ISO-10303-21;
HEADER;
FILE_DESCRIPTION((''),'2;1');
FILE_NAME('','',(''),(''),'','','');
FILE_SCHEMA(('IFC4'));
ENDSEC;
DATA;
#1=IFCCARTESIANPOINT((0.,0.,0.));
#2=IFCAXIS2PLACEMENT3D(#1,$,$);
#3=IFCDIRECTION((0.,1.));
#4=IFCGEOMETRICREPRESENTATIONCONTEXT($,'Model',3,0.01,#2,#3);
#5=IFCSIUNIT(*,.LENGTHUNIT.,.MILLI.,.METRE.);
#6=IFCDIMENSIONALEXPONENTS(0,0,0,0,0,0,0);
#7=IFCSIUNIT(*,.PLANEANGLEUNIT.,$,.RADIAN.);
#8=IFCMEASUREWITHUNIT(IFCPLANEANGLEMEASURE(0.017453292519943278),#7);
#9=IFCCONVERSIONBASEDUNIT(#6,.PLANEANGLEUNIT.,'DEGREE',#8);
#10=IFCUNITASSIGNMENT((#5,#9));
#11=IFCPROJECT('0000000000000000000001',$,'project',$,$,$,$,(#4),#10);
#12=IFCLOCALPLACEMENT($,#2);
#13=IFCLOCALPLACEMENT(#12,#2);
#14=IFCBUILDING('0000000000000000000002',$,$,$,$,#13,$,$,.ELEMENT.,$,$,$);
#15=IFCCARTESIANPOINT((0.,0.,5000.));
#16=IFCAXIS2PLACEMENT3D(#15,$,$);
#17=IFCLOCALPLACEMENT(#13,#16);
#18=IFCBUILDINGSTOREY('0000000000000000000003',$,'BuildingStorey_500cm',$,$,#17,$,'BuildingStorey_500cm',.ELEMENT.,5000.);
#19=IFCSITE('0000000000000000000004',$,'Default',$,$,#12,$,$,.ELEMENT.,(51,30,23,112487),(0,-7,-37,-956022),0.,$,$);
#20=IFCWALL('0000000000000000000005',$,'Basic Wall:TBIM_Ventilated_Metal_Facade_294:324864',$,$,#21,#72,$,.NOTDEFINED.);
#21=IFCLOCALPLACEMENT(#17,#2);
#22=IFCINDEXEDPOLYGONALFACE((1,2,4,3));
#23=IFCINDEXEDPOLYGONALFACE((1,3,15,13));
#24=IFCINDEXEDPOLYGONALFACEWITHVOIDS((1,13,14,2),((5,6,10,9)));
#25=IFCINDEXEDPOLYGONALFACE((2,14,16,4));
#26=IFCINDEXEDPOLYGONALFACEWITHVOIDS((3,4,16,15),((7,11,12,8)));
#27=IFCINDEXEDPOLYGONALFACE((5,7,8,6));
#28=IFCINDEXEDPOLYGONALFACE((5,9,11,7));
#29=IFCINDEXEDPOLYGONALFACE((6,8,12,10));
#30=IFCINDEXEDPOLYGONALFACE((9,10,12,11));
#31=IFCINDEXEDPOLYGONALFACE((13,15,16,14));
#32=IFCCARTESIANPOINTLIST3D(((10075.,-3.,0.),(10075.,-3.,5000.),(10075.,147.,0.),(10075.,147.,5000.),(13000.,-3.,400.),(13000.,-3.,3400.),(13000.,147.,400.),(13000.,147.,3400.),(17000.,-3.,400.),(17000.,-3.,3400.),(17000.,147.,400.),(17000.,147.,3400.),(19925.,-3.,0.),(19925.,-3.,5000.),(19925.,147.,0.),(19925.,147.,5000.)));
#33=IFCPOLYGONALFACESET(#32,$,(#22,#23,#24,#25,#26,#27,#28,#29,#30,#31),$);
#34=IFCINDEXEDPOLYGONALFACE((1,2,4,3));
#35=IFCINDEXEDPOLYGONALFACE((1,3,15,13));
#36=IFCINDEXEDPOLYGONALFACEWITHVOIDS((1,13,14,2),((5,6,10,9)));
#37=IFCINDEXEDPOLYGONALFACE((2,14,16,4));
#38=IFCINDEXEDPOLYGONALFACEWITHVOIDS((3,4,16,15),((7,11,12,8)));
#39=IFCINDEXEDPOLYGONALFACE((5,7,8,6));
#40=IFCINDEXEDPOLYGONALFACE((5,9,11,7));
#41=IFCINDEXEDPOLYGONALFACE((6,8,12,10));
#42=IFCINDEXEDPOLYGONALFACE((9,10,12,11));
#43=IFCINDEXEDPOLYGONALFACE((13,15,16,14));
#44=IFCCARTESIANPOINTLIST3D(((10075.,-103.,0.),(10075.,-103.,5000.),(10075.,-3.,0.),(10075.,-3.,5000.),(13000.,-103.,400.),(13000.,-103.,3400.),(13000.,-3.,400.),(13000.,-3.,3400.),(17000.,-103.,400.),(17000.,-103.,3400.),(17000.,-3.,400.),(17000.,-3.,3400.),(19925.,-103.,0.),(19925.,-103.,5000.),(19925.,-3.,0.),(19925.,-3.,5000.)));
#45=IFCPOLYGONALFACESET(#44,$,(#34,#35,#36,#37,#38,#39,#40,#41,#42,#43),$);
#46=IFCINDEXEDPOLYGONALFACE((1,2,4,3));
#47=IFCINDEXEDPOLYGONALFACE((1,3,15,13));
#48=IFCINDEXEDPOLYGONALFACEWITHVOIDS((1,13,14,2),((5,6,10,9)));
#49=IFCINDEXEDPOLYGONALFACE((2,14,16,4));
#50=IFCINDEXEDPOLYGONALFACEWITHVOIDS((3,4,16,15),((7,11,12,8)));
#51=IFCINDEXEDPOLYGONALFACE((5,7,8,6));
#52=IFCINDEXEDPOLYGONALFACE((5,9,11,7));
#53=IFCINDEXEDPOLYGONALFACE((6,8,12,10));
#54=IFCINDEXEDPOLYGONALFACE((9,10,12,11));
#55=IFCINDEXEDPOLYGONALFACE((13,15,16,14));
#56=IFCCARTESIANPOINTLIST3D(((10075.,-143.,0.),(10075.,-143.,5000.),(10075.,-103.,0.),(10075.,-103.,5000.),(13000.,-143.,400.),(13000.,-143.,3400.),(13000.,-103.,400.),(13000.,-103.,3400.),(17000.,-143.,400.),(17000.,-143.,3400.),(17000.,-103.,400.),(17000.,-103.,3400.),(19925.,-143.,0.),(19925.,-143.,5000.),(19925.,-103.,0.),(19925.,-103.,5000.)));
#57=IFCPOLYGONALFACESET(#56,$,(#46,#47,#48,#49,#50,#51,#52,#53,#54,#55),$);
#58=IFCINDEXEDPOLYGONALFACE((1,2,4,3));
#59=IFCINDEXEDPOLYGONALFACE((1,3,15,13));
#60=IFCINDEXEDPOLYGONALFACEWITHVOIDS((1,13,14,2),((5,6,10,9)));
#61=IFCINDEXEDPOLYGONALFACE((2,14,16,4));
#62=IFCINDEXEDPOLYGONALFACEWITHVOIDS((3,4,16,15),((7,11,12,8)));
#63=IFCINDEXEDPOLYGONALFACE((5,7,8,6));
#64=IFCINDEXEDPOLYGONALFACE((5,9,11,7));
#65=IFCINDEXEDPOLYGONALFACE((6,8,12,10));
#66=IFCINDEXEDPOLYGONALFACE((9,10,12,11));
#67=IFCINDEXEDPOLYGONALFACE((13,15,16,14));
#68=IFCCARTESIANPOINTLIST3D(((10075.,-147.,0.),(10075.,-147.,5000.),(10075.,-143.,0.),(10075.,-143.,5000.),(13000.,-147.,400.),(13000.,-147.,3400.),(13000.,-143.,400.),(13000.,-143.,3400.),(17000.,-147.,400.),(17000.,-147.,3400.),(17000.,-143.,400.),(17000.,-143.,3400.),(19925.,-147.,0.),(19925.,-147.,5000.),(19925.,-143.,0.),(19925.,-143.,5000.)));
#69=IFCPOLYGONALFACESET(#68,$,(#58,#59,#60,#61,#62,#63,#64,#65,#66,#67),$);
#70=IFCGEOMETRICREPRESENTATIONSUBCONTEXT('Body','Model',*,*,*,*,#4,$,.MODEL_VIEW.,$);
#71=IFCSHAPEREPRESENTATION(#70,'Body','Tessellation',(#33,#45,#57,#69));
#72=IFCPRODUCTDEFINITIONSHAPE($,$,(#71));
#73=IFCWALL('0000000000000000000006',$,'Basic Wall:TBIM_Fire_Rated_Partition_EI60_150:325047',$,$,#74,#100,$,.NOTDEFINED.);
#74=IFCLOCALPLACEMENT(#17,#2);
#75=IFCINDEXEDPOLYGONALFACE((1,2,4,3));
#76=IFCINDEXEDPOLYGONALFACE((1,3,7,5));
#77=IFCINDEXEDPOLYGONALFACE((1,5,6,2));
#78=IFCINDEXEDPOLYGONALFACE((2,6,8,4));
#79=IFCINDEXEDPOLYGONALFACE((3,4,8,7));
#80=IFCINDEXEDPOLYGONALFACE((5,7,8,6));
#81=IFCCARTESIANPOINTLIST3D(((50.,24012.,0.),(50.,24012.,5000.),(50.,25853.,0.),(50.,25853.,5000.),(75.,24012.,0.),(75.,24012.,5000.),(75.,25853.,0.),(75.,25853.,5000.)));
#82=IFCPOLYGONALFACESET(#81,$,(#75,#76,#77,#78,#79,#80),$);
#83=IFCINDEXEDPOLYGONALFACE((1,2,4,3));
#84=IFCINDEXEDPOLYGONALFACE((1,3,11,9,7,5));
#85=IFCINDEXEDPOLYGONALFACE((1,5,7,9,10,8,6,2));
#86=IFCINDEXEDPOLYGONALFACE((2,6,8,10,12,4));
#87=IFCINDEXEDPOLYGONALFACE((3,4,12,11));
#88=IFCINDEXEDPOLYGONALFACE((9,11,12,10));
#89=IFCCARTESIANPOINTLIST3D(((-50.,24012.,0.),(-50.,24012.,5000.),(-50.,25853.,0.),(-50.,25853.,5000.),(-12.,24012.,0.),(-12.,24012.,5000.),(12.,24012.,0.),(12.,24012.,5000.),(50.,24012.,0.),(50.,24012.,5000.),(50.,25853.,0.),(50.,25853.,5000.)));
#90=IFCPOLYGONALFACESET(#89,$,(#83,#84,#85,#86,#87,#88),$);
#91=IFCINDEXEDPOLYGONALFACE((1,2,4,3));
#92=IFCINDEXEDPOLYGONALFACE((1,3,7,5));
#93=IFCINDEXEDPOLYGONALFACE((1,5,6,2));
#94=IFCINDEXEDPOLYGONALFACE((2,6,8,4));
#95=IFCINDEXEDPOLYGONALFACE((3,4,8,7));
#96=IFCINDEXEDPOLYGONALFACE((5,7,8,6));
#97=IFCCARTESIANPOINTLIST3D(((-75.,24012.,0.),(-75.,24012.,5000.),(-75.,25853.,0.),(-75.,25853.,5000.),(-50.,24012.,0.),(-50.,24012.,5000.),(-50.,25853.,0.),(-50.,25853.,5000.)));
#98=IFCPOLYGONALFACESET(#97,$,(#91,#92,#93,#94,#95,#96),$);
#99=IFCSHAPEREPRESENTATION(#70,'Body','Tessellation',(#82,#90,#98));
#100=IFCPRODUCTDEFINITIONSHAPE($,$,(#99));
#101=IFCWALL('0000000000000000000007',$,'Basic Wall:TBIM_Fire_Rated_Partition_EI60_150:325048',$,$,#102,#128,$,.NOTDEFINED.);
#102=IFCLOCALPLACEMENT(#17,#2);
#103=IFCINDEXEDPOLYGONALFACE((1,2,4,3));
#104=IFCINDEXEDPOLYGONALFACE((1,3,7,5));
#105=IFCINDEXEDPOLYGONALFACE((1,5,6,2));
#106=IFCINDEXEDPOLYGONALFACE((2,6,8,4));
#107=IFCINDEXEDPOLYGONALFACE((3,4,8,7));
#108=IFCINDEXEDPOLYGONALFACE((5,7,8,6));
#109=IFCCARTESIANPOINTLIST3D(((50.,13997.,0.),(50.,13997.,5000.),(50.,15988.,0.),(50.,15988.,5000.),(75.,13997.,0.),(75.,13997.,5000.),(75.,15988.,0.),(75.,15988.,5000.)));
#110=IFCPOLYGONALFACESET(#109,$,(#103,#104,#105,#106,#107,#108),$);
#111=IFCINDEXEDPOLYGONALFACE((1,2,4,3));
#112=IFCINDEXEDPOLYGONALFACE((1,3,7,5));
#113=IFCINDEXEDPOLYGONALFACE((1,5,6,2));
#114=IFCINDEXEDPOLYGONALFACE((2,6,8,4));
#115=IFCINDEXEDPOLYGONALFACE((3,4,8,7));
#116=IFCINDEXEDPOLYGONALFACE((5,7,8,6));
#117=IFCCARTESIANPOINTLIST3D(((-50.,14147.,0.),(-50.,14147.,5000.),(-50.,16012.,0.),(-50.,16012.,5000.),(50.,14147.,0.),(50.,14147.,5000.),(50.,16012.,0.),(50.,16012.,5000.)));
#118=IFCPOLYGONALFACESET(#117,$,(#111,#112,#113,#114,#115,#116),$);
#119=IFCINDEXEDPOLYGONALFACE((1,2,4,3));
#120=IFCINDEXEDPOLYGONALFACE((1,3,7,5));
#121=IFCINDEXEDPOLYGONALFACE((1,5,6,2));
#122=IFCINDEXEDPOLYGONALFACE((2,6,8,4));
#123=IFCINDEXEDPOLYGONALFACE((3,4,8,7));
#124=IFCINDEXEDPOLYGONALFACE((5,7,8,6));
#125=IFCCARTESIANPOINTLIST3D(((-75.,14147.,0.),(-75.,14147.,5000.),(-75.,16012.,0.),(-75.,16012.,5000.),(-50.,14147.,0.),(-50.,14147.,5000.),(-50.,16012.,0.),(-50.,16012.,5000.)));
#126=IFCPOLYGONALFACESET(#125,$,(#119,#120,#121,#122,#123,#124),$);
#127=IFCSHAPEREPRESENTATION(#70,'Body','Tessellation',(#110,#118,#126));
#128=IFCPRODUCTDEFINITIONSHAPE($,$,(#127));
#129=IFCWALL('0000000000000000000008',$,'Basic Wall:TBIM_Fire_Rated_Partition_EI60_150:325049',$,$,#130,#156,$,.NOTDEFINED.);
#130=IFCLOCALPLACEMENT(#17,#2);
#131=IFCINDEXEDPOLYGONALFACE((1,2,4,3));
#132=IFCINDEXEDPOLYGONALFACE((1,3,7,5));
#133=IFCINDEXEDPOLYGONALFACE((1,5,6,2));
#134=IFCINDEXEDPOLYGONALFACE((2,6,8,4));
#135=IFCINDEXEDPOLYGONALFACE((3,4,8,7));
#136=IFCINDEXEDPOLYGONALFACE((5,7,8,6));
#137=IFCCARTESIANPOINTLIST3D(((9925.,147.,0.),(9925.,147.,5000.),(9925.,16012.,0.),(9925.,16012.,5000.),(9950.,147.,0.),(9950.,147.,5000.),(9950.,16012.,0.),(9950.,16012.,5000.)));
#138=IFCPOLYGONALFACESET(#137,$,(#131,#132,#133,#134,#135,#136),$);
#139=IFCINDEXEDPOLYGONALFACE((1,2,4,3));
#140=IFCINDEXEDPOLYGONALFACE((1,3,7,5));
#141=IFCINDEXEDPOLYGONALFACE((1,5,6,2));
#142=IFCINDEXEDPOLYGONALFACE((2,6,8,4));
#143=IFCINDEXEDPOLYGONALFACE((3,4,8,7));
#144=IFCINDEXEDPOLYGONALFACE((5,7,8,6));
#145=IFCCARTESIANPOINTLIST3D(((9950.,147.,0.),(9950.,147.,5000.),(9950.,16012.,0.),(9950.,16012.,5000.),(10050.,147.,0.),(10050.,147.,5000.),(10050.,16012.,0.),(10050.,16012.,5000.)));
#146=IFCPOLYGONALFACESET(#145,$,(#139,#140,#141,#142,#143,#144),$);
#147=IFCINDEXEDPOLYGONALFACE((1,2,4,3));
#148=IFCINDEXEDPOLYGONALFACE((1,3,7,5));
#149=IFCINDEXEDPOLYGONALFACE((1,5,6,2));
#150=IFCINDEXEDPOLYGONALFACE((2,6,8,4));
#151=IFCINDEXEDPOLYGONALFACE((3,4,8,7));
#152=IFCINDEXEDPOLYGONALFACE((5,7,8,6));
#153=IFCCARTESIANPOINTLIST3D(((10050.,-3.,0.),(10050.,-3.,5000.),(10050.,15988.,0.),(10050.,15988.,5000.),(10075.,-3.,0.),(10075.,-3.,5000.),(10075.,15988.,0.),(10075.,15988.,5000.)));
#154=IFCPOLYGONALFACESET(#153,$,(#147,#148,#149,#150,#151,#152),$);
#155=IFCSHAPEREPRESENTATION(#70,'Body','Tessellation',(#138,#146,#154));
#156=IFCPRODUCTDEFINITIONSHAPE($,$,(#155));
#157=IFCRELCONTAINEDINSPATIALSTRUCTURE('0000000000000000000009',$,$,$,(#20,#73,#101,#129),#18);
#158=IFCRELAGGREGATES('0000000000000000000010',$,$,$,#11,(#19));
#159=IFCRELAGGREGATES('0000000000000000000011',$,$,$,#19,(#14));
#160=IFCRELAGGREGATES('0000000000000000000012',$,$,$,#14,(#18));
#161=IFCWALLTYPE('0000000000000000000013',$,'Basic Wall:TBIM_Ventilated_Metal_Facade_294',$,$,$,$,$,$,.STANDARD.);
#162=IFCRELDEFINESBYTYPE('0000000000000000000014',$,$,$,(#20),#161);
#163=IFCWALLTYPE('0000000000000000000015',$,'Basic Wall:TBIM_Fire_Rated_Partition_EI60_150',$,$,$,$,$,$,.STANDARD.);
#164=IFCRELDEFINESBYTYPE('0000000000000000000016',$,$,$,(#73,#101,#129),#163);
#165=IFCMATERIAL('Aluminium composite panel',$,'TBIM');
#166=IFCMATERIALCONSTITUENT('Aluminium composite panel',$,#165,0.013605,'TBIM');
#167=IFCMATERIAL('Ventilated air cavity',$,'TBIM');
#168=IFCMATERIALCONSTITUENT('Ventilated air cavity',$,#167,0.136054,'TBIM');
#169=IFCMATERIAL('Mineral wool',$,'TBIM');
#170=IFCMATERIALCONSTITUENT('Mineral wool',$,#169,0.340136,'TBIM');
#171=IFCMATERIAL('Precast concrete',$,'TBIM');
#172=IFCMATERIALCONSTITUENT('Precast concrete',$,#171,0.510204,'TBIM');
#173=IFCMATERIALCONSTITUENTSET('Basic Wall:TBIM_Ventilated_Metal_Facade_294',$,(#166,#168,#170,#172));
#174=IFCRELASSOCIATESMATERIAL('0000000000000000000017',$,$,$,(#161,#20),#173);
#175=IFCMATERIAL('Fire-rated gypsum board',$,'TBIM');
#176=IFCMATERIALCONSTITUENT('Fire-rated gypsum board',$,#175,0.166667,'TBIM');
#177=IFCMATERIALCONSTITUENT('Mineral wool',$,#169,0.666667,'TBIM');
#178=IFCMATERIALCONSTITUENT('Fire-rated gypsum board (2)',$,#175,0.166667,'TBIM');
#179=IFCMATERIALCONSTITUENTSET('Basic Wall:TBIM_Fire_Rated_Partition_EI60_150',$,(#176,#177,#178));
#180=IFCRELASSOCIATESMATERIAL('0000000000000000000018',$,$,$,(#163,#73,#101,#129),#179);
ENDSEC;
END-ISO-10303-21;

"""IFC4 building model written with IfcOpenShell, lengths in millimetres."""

from ifc_helpers import new_model, entity, si_unit, converted_unit, direction, frame, origin, place, context, subcontext, project, spatial, indexed_curve, outline, extrude, material, constituent, constituent_set, type_object, element, save


model = new_model("IFC4")

# Units and contexts
model_context = context("Model", 3, precision=0.01, world=origin(), true_north=direction((0.0, 1.0)))
body_context = subcontext(model_context, "Body", "Model", "MODEL_VIEW")
ifc_project = project(units=[si_unit("LENGTHUNIT", "METRE", prefix="MILLI"), converted_unit("PLANEANGLEUNIT", "DEGREE", entity("IfcPlaneAngleMeasure", 0.017453292519943278), si_unit("PLANEANGLEUNIT", "RADIAN"), dimensions=[0, 0, 0, 0, 0, 0, 0])], contexts=[model_context])

# Site, building, storey
site_placement = place(None, origin())
site = spatial("IfcSite", under=ifc_project, at=site_placement, Name="Default", CompositionType="ELEMENT", RefLatitude=(51, 30, 23, 112487), RefLongitude=(0, -7, -37, -956022), RefElevation=0.0)
building_placement = place(site_placement, origin())
building = spatial("IfcBuilding", under=site, at=building_placement, CompositionType="ELEMENT")
storey_placement = place(building_placement, frame((0.0, 0.0, 5000.0)))
storey = spatial("IfcBuildingStorey", under=building, at=storey_placement, Name="BuildingStorey_500cm", LongName="BuildingStorey_500cm", CompositionType="ELEMENT", Elevation=5000.0)

# Shared definitions
ifc_material_1 = material(Name="Aluminium composite panel", Category="TBIM")
ifc_constituent_1 = constituent(ifc_material_1, Name="Aluminium composite panel", Category="TBIM", fraction=0.013605)
ifc_material_2 = material(Name="Ventilated air cavity", Category="TBIM")
ifc_constituent_2 = constituent(ifc_material_2, Name="Ventilated air cavity", Category="TBIM", fraction=0.136054)
ifc_material_3 = material(Name="Mineral wool", Category="TBIM")
ifc_constituent_3 = constituent(ifc_material_3, Name="Mineral wool", Category="TBIM", fraction=0.340136)
ifc_material_4 = material(Name="Precast concrete", Category="TBIM")
ifc_constituent_4 = constituent(ifc_material_4, Name="Precast concrete", Category="TBIM", fraction=0.510204)
ifc_constituent_set_1 = constituent_set(constituents=[ifc_constituent_1, ifc_constituent_2, ifc_constituent_3, ifc_constituent_4], Name="Basic Wall:TBIM_Ventilated_Metal_Facade_294")
wall_type_1 = type_object("IfcWallType", Name="Basic Wall:TBIM_Ventilated_Metal_Facade_294", PredefinedType="STANDARD", material=ifc_constituent_set_1)

# Wall, opening
wall_1_placement = place(storey_placement, frame((10075.0, 0.0, 0.0)))
wall_1 = element("IfcWall", 1, at=wall_1_placement, inside=storey, type_object=wall_type_1, material=ifc_constituent_set_1, Name="Basic Wall:TBIM_Ventilated_Metal_Facade_294:324864", PredefinedType="NOTDEFINED", context=body_context, shape_type="SweptSolid", body=[
    extrude(outline(indexed_curve([(-2500.0, -4925.0), (2500.0, -4925.0), (2500.0, 4925.0), (-2500.0, 4925.0), (-2500.0, -4925.0)], self_intersect=False), holes=[indexed_curve([(-2100.0, -2000.0), (-2100.0, 2000.0), (900.0, 2000.0), (900.0, -2000.0), (-2100.0, -2000.0)], self_intersect=False)]), frame((4925.0, -3.0, 2500.0), z_axis=(0.0, 1.0, 0.0), x_axis=(0.0, 0.0, 1.0)), (0.0, 0.0, 1.0), 150.0),
    extrude(outline(indexed_curve([(-2500.0, -4925.0), (2500.0, -4925.0), (2500.0, 4925.0), (-2500.0, 4925.0), (-2500.0, -4925.0)], self_intersect=False), holes=[indexed_curve([(-2100.0, -2000.0), (-2100.0, 2000.0), (900.0, 2000.0), (900.0, -2000.0), (-2100.0, -2000.0)], self_intersect=False)]), frame((4925.0, -103.0, 2500.0), z_axis=(0.0, 1.0, 0.0), x_axis=(0.0, 0.0, 1.0)), (0.0, 0.0, 1.0), 100.0),
    extrude(outline(indexed_curve([(-2500.0, -4925.0), (2500.0, -4925.0), (2500.0, 4925.0), (-2500.0, 4925.0), (-2500.0, -4925.0)], self_intersect=False), holes=[indexed_curve([(-2100.0, -2000.0), (-2100.0, 2000.0), (900.0, 2000.0), (900.0, -2000.0), (-2100.0, -2000.0)], self_intersect=False)]), frame((4925.0, -143.0, 2500.0), z_axis=(0.0, 1.0, 0.0), x_axis=(0.0, 0.0, 1.0)), (0.0, 0.0, 1.0), 40.0),
    extrude(outline(indexed_curve([(-2500.0, -4925.0), (2500.0, -4925.0), (2500.0, 4925.0), (-2500.0, 4925.0), (-2500.0, -4925.0)], self_intersect=False), holes=[indexed_curve([(900.0, -2000.0), (-2100.0, -2000.0), (-2100.0, 2000.0), (900.0, 2000.0), (900.0, -2000.0)], self_intersect=False)]), frame((4925.0, -147.0, 2500.0), z_axis=(0.0, 1.0, 0.0), x_axis=(0.0, 0.0, 1.0)), (0.0, 0.0, 1.0), 4.0),
])
opening_1_placement = place(wall_1_placement, frame((2925.0, -147.0, 400.0)))
element("IfcOpeningElement", 2, at=opening_1_placement, cuts=wall_1, PredefinedType="OPENING", context=body_context, shape_type="SweptSolid", body=[
    extrude(outline(indexed_curve([(3000.0, 0.0), (3000.0, 4000.0), (0.0, 4000.0), (0.0, 0.0), (3000.0, 0.0)], self_intersect=False)), frame((0.0, 0.0, 0.0), z_axis=(0.0, 1.0, 0.0), x_axis=(0.0, 0.0, 1.0)), (0.0, 0.0, 1.0), 294.0),
])

# Walls
ifc_material_5 = material(Name="Fire-rated gypsum board", Category="TBIM")
ifc_constituent_5 = constituent(ifc_material_5, Name="Fire-rated gypsum board", Category="TBIM", fraction=0.166667)
ifc_constituent_6 = constituent(ifc_material_3, Name="Mineral wool", Category="TBIM", fraction=0.666667)
ifc_constituent_7 = constituent(ifc_material_5, Name="Fire-rated gypsum board (2)", Category="TBIM", fraction=0.166667)
ifc_constituent_set_2 = constituent_set(constituents=[ifc_constituent_5, ifc_constituent_6, ifc_constituent_7], Name="Basic Wall:TBIM_Fire_Rated_Partition_EI60_150")
wall_type_2 = type_object("IfcWallType", Name="Basic Wall:TBIM_Fire_Rated_Partition_EI60_150", PredefinedType="STANDARD", material=ifc_constituent_set_2)
wall_2_placement = place(storey_placement, frame((0.0, 25853.0, 0.0), z_axis=(0.0, 0.0, 1.0), x_axis=(0.0, -1.0, 0.0)))
element("IfcWall", 3, at=wall_2_placement, inside=storey, type_object=wall_type_2, material=ifc_constituent_set_2, Name="Basic Wall:TBIM_Fire_Rated_Partition_EI60_150:325047", PredefinedType="NOTDEFINED", context=body_context, shape_type="SweptSolid", body=[
    extrude(outline(indexed_curve([(-12.5, -920.5), (12.5, -920.5), (12.5, 920.5), (-12.5, 920.5), (-12.5, -920.5)], self_intersect=False)), frame((920.5, 62.5, 0.0), z_axis=(0.0, 0.0, 1.0), x_axis=(0.0, -1.0, 0.0)), (0.0, 0.0, 1.0), 5000.0),
    extrude(outline(indexed_curve([(12.0, -613.7), (50.0, -613.7), (50.0, 1227.3), (-50.0, 1227.3), (-50.0, -613.7), (-12.0, -613.7), (12.0, -613.7)], self_intersect=False)), frame((1227.3, 0.0, 0.0), z_axis=(0.0, 0.0, 1.0), x_axis=(0.0, 1.0, 0.0)), (0.0, 0.0, 1.0), 5000.0),
    extrude(outline(indexed_curve([(-12.5, -920.5), (12.5, -920.5), (12.5, 920.5), (-12.5, 920.5), (-12.5, -920.5)], self_intersect=False)), frame((920.5, -62.5, 0.0), z_axis=(0.0, 0.0, 1.0), x_axis=(0.0, 1.0, 0.0)), (0.0, 0.0, 1.0), 5000.0),
])
wall_3_placement = place(storey_placement, frame((0.0, 15988.0, 0.0), z_axis=(0.0, 0.0, 1.0), x_axis=(0.0, -1.0, 0.0)))
element("IfcWall", 4, at=wall_3_placement, inside=storey, type_object=wall_type_2, material=ifc_constituent_set_2, Name="Basic Wall:TBIM_Fire_Rated_Partition_EI60_150:325048", PredefinedType="NOTDEFINED", context=body_context, shape_type="SweptSolid", body=[
    extrude(outline(indexed_curve([(-12.5, -995.5), (12.5, -995.5), (12.5, 995.5), (-12.5, 995.5), (-12.5, -995.5)], self_intersect=False)), frame((995.5, 62.5, 0.0), z_axis=(0.0, 0.0, 1.0), x_axis=(0.0, -1.0, 0.0)), (0.0, 0.0, 1.0), 5000.0),
    extrude(outline(indexed_curve([(-932.5, -50.0), (932.5, -50.0), (932.5, 50.0), (-932.5, 50.0), (-932.5, -50.0)], self_intersect=False)), frame((908.5, 0.0, 0.0)), (0.0, 0.0, 1.0), 5000.0),
    extrude(outline(indexed_curve([(-12.5, -932.5), (12.5, -932.5), (12.5, 932.5), (-12.5, 932.5), (-12.5, -932.5)], self_intersect=False)), frame((908.5, -62.5, 0.0), z_axis=(0.0, 0.0, 1.0), x_axis=(0.0, 1.0, 0.0)), (0.0, 0.0, 1.0), 5000.0),
])
wall_4_placement = place(storey_placement, frame((10000.0, 147.0, 0.0), z_axis=(0.0, 0.0, 1.0), x_axis=(0.0, 1.0, 0.0)))
element("IfcWall", 5, at=wall_4_placement, inside=storey, type_object=wall_type_2, material=ifc_constituent_set_2, Name="Basic Wall:TBIM_Fire_Rated_Partition_EI60_150:325049", PredefinedType="NOTDEFINED", context=body_context, shape_type="SweptSolid", body=[
    extrude(outline(indexed_curve([(-12.5, -7932.5), (12.5, -7932.5), (12.5, 7932.5), (-12.5, 7932.5), (-12.5, -7932.5)], self_intersect=False)), frame((7932.5, 62.5, 0.0), z_axis=(0.0, 0.0, 1.0), x_axis=(0.0, -1.0, 0.0)), (0.0, 0.0, 1.0), 5000.0),
    extrude(outline(indexed_curve([(-7932.5, -50.0), (7932.5, -50.0), (7932.5, 50.0), (-7932.5, 50.0), (-7932.5, -50.0)], self_intersect=False)), frame((7932.5, 0.0, 0.0)), (0.0, 0.0, 1.0), 5000.0),
    extrude(outline(indexed_curve([(-12.5, -7995.5), (12.5, -7995.5), (12.5, 7995.5), (-12.5, 7995.5), (-12.5, -7995.5)], self_intersect=False)), frame((7845.5, -62.5, 0.0), z_axis=(0.0, 0.0, 1.0), x_axis=(0.0, 1.0, 0.0)), (0.0, 0.0, 1.0), 5000.0),
])

save(model, "model.ifc")
